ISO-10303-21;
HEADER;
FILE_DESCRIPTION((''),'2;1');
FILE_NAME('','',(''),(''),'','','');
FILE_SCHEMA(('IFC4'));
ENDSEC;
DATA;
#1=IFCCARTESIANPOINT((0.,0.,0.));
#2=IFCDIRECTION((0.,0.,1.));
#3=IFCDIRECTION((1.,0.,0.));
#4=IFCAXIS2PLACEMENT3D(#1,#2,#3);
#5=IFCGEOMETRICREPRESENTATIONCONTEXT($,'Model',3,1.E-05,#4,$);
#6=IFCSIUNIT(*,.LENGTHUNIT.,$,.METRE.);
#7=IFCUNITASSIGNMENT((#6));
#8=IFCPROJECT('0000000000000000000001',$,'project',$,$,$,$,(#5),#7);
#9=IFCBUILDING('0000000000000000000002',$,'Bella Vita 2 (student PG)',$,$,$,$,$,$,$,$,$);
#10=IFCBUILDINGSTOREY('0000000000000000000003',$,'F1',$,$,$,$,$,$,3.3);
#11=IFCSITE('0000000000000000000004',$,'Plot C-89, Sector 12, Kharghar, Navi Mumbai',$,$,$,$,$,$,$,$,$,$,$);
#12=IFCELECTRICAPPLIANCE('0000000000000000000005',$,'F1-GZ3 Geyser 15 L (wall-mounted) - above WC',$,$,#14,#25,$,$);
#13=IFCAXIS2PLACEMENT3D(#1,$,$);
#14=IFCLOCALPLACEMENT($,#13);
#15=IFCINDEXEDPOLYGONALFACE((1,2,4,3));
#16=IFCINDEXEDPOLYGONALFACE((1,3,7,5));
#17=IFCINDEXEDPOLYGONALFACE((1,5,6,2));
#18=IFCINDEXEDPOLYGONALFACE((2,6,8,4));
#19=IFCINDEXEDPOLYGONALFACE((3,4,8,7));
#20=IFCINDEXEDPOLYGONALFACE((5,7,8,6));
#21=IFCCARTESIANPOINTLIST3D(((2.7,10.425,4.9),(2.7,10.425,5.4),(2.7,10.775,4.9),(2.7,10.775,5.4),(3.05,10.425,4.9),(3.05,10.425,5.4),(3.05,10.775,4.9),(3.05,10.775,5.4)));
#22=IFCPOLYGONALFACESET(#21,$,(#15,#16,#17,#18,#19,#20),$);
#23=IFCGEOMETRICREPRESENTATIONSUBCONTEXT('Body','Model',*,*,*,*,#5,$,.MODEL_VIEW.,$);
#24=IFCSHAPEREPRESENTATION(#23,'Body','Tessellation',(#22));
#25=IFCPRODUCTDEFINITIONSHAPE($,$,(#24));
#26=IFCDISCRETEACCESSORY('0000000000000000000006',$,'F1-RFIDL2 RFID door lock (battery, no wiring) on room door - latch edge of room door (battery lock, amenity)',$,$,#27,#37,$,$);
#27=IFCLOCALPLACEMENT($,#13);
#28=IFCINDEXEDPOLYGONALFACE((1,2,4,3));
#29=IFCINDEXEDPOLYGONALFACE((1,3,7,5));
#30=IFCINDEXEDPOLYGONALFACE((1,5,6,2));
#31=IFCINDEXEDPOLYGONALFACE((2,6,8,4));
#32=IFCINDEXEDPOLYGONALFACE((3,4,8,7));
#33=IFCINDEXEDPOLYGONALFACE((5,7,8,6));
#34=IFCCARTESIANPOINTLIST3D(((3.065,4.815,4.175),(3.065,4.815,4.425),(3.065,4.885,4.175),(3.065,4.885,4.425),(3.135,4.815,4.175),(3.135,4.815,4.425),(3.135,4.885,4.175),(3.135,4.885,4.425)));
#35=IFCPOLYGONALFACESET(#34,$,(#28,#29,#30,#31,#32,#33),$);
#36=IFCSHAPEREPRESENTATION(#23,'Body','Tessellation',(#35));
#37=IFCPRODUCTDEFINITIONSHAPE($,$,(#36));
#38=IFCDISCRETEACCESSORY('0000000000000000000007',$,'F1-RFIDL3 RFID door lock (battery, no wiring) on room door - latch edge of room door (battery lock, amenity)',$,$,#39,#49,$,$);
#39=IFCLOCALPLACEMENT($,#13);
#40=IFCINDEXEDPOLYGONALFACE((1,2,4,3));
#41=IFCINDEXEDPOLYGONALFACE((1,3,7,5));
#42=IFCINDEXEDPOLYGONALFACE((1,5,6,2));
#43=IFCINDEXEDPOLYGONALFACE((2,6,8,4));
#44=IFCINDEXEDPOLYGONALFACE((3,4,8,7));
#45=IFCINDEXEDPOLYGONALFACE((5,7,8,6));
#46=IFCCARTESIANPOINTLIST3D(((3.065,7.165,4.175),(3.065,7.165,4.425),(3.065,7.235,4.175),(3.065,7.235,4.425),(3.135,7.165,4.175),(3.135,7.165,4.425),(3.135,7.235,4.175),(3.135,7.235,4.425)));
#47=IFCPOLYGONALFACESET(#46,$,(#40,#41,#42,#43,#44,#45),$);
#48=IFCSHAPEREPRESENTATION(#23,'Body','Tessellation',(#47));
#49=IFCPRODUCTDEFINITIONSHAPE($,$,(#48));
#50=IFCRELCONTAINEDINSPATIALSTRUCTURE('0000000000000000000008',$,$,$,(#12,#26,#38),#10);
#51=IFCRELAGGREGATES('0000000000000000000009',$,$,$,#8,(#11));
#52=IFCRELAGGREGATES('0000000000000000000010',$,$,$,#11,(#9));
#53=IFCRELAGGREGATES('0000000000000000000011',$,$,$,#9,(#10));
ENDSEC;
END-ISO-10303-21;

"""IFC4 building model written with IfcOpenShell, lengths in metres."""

from ifc_helpers import new_model, si_unit, frame, origin, origin_with_axes, origin_2d, place, context, subcontext, project, spatial, rectangle, extrude, element, save


model = new_model("IFC4")

# Units and contexts
model_context = context("Model", 3, precision=1e-05, world=origin_with_axes())
body_context = subcontext(model_context, "Body", "Model", "MODEL_VIEW")
ifc_project = project(units=[si_unit("LENGTHUNIT", "METRE")], contexts=[model_context])

# Site, building, storey
site = spatial("IfcSite", under=ifc_project, Name="Plot C-89, Sector 12, Kharghar, Navi Mumbai")
building = spatial("IfcBuilding", under=site, Name="Bella Vita 2 (student PG)")
storey = spatial("IfcBuildingStorey", under=building, Name="F1", Elevation=3.3)

# Electric appliance
electric_appliance_1_placement = place(None, origin())
element("IfcElectricAppliance", 1, at=electric_appliance_1_placement, inside=storey, Name="F1-GZ3 Geyser 15 L (wall-mounted) - above WC", context=body_context, shape_type="SweptSolid", body=[
    extrude(rectangle(XDim=0.35, YDim=0.35, at=origin_2d()), frame((2.875, 10.6, 4.9)), (0.0, 0.0, 1.0), 0.5),
])

# Discrete accessories
discrete_accessory_1_placement = place(None, origin())
element("IfcDiscreteAccessory", 2, at=discrete_accessory_1_placement, inside=storey, Name="F1-RFIDL2 RFID door lock (battery, no wiring) on room door - latch edge of room door (battery lock, amenity)", context=body_context, shape_type="SweptSolid", body=[
    extrude(rectangle(XDim=0.07, YDim=0.07, at=origin_2d()), frame((3.1, 4.85, 4.175)), (0.0, 0.0, 1.0), 0.25),
])
discrete_accessory_2_placement = place(None, origin())
element("IfcDiscreteAccessory", 3, at=discrete_accessory_2_placement, inside=storey, Name="F1-RFIDL3 RFID door lock (battery, no wiring) on room door - latch edge of room door (battery lock, amenity)", context=body_context, shape_type="SweptSolid", body=[
    extrude(rectangle(XDim=0.07, YDim=0.07, at=origin_2d()), frame((3.1, 7.2, 4.175)), (0.0, 0.0, 1.0), 0.25),
])

save(model, "model.ifc")
